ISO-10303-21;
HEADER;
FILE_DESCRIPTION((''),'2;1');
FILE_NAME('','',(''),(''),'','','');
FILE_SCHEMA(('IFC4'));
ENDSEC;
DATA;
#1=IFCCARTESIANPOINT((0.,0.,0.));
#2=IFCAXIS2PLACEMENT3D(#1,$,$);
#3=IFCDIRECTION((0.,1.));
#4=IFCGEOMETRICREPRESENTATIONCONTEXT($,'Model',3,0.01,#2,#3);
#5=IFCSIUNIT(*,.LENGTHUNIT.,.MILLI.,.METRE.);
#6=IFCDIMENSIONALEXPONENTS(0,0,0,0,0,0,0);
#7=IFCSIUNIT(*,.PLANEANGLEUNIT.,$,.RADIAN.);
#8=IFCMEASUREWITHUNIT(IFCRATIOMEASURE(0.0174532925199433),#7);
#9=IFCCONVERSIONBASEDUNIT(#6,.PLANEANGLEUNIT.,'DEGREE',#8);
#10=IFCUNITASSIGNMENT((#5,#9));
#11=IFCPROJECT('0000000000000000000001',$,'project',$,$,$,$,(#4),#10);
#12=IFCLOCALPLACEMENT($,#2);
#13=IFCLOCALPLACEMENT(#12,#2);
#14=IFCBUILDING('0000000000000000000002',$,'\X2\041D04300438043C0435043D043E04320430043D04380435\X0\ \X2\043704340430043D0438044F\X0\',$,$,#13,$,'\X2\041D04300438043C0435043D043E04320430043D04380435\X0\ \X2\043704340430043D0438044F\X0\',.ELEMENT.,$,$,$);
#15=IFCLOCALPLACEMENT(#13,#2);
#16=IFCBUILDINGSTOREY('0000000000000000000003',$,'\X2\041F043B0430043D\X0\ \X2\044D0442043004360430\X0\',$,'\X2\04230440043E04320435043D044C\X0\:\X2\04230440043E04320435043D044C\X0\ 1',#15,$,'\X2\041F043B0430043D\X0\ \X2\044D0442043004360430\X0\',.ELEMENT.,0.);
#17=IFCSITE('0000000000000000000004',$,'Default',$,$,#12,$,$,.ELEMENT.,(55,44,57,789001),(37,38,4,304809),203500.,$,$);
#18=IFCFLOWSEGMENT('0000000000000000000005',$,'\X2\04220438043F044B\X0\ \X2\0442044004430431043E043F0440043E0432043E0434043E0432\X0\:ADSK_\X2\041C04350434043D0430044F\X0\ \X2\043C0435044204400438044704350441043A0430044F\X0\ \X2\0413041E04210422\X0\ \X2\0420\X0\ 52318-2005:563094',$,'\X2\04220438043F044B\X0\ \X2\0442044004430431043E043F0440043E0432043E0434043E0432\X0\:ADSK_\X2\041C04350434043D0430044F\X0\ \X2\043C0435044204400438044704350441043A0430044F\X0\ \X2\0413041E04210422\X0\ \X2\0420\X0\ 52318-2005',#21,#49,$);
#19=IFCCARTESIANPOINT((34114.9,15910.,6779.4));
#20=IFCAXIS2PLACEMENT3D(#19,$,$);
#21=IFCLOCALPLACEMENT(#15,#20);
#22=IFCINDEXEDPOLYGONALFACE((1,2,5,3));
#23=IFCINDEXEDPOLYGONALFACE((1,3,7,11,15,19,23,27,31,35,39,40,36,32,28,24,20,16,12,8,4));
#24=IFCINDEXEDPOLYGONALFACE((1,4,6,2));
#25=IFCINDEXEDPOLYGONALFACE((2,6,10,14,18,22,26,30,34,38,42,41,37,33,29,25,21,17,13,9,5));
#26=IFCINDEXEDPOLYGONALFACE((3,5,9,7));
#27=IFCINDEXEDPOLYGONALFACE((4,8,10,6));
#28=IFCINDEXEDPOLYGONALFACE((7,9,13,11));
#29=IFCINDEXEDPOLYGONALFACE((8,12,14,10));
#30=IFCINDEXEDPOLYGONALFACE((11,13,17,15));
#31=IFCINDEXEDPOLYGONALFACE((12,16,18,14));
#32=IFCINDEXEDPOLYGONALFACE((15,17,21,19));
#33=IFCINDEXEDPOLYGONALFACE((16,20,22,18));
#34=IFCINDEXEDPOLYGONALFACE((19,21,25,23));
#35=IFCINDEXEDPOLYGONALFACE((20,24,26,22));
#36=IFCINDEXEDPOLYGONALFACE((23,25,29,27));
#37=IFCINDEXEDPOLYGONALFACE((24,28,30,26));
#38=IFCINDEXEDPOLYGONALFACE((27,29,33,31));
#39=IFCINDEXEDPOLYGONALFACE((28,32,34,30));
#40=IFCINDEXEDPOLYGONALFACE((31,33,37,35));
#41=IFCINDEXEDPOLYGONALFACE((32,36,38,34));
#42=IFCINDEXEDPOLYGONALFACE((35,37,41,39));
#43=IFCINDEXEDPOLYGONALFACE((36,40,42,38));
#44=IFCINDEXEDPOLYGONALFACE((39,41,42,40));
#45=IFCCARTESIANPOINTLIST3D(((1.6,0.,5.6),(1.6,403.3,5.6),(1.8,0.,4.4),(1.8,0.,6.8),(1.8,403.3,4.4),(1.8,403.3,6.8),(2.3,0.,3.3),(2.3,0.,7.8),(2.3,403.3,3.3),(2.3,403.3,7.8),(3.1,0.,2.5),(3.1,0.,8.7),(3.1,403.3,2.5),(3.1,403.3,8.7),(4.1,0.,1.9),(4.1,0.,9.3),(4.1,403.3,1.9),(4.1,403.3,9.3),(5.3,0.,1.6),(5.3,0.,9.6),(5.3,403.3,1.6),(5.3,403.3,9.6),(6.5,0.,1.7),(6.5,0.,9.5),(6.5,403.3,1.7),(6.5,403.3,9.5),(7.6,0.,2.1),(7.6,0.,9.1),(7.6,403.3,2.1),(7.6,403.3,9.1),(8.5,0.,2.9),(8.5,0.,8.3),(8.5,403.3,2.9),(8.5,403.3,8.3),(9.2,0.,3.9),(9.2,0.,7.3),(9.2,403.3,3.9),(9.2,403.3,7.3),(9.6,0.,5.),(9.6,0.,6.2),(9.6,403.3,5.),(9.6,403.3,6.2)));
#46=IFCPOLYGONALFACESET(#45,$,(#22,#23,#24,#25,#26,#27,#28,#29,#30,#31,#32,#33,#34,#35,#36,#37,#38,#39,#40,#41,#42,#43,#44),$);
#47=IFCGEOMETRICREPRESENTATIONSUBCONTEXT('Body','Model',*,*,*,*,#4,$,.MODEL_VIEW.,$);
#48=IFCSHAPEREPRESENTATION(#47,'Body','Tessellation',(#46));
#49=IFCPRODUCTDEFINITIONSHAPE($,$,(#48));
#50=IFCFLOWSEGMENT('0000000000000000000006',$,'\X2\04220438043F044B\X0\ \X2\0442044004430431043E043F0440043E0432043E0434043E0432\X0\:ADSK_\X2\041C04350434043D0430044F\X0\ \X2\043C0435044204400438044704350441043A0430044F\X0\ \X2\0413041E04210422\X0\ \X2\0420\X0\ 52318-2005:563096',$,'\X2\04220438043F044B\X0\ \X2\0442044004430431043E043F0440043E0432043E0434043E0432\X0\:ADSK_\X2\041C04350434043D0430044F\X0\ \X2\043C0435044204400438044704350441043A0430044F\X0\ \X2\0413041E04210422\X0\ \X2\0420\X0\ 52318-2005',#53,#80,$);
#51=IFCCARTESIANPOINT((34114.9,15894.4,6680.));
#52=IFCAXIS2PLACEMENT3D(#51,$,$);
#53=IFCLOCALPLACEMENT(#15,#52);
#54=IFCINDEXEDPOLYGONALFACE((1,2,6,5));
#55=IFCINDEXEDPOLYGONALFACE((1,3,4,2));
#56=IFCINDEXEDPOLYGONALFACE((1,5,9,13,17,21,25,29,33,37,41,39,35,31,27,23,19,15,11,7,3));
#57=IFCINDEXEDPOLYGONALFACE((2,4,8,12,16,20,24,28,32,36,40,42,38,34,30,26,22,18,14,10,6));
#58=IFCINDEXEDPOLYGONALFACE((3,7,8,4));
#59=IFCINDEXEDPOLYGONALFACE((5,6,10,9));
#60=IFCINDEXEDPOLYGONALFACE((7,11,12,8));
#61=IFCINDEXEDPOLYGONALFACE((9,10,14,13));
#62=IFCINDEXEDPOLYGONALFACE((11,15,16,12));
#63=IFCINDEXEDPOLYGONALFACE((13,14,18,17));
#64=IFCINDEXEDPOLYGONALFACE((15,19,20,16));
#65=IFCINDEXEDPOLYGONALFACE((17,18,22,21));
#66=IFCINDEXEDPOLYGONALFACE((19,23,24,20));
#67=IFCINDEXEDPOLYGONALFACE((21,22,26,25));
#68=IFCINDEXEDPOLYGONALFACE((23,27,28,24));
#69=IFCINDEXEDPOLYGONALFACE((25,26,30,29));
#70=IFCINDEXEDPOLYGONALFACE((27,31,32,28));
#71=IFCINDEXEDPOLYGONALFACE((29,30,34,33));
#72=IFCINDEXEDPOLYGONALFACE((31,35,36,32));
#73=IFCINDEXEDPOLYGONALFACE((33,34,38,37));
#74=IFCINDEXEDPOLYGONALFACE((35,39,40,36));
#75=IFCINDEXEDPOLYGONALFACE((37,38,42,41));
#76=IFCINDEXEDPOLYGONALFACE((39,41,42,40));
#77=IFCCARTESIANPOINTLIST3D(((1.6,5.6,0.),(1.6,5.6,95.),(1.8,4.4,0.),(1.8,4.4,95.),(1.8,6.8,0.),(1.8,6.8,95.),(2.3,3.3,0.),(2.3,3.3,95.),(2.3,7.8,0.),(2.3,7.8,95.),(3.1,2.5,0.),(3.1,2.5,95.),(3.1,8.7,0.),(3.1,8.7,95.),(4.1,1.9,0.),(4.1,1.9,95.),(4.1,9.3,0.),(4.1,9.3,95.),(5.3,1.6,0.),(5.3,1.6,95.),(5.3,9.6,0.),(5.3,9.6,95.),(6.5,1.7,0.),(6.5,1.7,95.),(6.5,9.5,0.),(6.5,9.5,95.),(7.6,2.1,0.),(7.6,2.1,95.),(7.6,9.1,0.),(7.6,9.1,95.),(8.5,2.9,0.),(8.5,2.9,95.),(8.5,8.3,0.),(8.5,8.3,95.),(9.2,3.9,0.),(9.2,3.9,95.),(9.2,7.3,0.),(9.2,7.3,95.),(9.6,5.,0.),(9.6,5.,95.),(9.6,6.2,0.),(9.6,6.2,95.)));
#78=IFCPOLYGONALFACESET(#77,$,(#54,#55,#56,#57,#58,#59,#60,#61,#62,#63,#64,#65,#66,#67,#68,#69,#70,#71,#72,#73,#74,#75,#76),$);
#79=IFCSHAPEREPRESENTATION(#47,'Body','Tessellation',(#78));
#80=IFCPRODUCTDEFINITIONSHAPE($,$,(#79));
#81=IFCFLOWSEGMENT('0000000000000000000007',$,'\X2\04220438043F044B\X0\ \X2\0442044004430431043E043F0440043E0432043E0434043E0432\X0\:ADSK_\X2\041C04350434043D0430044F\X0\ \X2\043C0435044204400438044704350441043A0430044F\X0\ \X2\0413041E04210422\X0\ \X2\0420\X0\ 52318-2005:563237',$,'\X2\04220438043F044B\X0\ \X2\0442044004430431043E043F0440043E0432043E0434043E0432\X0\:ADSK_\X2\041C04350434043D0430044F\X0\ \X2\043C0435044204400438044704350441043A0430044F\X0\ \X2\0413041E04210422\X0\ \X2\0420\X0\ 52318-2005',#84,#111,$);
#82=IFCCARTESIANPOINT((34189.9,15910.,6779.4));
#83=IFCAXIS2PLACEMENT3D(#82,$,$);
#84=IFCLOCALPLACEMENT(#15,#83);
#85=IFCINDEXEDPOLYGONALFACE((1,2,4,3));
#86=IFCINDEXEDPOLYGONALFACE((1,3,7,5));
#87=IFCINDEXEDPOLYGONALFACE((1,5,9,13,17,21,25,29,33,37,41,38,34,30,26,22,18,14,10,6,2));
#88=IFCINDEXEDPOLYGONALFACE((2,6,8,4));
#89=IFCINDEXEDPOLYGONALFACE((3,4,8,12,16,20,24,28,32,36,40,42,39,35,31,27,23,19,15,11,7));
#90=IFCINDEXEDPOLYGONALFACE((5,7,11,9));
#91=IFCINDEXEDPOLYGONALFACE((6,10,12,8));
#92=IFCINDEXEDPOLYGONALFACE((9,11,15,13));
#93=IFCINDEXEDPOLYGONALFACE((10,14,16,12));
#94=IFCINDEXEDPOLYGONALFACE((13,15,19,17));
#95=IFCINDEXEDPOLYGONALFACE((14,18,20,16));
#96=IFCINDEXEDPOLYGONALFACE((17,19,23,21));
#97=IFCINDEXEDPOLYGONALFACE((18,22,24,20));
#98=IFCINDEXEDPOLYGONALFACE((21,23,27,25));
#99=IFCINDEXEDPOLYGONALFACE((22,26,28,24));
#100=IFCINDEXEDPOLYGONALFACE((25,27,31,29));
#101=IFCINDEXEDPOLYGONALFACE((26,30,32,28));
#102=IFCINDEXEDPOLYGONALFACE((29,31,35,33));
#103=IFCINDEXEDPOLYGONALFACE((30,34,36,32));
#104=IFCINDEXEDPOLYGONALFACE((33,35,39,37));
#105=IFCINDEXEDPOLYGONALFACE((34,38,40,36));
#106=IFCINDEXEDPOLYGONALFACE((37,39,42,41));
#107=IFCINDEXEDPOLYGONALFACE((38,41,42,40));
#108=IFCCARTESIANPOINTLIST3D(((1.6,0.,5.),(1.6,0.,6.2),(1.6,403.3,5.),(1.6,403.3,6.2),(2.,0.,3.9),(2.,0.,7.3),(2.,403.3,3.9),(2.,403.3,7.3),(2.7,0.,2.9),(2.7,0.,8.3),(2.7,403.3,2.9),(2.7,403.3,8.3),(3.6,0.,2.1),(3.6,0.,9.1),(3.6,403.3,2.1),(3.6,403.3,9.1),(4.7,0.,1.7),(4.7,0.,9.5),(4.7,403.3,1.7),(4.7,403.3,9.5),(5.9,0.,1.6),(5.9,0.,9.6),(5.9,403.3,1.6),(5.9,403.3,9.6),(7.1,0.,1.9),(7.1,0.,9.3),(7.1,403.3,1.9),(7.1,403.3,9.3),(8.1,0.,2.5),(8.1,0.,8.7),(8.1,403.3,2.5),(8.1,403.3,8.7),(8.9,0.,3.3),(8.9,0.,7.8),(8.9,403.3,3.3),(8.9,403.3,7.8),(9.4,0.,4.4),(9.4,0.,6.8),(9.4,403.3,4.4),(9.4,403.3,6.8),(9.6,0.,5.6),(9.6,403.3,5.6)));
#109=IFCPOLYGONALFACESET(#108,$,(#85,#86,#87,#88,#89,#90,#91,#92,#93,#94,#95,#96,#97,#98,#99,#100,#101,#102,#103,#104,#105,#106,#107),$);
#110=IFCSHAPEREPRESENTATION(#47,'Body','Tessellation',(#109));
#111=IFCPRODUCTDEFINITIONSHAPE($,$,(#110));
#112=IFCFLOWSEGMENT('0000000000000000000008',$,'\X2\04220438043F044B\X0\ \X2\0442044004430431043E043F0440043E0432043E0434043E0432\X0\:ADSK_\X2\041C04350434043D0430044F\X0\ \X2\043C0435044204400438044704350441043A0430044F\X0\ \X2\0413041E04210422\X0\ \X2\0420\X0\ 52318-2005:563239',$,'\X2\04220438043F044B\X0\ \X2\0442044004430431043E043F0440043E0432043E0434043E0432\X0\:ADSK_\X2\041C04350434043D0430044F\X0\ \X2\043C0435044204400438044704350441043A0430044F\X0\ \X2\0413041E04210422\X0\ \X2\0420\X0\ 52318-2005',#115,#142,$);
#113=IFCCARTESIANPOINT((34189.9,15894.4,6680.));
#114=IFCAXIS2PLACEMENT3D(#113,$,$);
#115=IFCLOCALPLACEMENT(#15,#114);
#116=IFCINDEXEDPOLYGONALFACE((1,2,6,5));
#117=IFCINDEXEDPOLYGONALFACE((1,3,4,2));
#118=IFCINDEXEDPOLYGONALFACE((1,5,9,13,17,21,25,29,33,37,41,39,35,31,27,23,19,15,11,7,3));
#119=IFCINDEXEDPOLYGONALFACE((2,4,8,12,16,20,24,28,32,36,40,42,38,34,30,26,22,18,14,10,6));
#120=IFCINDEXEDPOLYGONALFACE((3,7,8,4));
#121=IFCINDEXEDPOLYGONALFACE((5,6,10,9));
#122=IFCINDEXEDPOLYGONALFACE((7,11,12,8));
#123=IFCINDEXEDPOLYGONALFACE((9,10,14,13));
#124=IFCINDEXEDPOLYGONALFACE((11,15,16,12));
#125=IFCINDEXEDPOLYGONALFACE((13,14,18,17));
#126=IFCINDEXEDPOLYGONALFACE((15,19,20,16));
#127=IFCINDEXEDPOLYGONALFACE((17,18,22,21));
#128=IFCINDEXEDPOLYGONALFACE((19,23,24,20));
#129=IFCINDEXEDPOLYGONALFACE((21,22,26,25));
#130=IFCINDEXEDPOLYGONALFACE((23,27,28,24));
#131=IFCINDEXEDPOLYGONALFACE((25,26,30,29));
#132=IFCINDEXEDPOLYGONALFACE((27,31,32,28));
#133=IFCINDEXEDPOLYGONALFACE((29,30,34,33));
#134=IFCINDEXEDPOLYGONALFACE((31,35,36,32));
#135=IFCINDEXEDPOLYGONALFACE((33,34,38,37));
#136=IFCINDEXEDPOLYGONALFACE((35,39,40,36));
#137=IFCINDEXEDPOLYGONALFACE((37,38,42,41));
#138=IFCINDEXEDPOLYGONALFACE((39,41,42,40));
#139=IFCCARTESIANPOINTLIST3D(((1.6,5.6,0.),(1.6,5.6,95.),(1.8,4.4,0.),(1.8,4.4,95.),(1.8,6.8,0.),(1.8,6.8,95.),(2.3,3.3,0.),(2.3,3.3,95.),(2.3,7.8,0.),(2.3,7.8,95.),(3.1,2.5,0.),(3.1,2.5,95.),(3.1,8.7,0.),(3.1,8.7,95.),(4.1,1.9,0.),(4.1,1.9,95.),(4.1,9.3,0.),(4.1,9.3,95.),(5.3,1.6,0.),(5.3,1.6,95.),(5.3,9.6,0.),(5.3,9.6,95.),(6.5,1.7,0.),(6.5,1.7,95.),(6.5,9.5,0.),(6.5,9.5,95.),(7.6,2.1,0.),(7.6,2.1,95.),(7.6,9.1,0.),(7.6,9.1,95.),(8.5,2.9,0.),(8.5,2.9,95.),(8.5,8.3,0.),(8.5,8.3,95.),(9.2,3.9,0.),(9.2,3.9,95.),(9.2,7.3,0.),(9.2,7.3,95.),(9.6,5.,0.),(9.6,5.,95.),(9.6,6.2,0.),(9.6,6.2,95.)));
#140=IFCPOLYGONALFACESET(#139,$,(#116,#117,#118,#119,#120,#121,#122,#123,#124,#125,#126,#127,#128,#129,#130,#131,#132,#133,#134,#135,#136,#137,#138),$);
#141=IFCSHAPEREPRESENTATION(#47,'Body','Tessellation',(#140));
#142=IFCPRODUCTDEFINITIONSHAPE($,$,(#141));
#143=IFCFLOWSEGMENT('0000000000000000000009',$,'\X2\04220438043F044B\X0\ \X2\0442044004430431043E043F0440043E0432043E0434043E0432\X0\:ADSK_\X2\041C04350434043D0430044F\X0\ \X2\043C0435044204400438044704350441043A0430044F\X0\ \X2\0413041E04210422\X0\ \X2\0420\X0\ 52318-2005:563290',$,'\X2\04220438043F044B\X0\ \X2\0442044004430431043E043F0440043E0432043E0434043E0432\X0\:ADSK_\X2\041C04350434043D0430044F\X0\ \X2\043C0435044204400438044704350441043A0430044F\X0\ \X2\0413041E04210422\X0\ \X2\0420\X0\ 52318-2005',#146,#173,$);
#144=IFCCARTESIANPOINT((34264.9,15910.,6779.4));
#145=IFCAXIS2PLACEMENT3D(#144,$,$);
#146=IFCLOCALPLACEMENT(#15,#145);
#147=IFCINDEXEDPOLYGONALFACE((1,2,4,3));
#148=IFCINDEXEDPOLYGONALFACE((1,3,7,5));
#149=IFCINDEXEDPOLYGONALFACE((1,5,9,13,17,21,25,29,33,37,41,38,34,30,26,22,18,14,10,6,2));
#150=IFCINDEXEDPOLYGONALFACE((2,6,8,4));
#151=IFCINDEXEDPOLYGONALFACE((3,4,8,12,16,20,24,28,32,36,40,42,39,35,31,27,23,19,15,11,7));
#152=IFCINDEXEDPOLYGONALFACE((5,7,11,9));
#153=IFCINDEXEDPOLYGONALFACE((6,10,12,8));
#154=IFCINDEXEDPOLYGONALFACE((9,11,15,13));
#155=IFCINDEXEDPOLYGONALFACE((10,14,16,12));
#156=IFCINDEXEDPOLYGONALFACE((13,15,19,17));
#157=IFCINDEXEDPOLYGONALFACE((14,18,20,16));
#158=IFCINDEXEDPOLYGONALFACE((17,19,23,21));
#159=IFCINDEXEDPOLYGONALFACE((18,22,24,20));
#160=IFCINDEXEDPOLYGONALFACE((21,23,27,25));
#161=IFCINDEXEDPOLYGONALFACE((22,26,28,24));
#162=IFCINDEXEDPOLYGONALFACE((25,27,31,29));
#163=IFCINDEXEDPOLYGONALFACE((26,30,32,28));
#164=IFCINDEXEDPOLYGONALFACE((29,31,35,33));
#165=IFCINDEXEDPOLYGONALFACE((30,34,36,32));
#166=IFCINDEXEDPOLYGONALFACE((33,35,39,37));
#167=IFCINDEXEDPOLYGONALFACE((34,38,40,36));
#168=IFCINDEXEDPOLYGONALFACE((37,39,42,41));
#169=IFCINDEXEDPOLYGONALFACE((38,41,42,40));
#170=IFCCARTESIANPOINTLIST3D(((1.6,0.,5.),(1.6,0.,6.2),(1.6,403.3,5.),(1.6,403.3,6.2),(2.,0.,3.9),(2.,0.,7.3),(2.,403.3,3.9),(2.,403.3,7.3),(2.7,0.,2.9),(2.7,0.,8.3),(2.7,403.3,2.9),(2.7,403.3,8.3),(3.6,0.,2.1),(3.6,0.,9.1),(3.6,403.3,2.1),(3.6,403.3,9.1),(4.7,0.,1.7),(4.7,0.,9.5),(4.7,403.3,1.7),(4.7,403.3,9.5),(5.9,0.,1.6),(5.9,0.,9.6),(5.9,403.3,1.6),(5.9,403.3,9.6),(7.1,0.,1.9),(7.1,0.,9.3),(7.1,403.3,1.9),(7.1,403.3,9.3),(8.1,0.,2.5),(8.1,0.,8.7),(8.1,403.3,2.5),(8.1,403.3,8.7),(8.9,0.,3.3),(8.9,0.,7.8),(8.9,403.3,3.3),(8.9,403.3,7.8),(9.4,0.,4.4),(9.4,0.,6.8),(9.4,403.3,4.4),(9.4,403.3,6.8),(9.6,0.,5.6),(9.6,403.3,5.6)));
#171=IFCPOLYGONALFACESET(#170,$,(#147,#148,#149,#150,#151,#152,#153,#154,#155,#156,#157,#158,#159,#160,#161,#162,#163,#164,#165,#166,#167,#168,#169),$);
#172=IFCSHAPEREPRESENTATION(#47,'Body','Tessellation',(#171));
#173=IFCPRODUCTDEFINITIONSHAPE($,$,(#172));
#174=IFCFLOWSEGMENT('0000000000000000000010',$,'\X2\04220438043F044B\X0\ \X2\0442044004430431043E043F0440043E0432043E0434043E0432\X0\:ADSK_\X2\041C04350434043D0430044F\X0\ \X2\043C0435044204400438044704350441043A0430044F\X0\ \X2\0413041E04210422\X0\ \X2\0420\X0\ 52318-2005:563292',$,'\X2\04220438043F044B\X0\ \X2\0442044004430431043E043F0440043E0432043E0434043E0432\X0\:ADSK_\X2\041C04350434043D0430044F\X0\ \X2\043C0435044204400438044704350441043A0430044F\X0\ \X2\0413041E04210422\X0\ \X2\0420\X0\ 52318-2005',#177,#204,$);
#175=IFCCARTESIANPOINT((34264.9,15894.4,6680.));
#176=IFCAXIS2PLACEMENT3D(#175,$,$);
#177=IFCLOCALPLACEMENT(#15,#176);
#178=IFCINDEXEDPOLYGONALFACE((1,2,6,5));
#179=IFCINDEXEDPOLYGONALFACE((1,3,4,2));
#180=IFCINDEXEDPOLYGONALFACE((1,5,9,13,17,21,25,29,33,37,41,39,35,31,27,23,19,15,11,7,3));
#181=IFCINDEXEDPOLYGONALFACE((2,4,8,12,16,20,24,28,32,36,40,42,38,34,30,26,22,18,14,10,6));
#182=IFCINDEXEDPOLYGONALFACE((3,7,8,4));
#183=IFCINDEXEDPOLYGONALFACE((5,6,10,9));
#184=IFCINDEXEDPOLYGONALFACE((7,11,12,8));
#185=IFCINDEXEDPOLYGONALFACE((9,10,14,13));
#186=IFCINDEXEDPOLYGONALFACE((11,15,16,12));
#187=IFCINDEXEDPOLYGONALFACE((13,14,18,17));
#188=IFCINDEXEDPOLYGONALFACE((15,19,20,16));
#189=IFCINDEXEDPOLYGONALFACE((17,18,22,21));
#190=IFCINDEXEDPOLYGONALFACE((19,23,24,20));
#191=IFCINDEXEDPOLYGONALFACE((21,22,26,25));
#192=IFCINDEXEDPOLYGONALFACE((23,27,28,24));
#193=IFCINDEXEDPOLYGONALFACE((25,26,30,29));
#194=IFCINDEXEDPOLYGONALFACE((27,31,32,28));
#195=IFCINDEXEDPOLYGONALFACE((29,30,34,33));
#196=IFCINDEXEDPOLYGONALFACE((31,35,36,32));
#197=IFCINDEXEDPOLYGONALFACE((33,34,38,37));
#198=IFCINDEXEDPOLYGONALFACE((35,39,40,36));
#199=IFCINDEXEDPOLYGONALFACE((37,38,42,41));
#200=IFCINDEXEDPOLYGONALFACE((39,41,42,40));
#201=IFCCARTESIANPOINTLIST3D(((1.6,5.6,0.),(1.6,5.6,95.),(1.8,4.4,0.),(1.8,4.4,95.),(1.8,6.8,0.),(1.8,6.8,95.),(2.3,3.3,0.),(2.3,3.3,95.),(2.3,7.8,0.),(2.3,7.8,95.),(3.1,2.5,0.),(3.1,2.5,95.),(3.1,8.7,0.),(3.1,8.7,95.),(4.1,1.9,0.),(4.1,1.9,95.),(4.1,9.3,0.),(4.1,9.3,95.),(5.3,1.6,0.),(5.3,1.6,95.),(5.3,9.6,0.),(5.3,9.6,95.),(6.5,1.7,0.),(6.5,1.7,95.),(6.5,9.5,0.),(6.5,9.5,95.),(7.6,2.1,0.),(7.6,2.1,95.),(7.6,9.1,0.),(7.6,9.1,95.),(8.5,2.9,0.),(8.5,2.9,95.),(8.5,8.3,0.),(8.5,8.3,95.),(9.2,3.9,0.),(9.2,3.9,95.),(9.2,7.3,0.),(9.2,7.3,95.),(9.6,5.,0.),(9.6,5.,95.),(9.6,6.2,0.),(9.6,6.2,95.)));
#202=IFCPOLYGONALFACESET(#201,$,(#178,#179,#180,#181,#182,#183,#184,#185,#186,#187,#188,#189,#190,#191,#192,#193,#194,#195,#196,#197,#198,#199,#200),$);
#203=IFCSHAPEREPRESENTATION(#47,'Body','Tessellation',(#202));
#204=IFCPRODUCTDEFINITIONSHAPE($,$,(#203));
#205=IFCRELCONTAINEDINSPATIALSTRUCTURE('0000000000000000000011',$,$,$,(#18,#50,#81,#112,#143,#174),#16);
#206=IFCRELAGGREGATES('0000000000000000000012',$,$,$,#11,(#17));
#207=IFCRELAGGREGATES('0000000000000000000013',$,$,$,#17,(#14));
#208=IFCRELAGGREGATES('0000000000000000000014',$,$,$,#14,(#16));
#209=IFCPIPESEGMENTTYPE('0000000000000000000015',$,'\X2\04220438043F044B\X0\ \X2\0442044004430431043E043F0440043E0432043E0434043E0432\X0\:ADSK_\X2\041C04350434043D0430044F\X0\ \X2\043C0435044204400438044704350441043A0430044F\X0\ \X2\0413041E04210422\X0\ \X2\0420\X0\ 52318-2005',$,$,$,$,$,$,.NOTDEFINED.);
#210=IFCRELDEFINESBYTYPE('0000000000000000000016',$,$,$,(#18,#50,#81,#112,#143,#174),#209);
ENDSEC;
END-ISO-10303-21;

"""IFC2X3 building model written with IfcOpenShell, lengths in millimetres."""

from ifc_helpers import new_model, entity, si_unit, converted_unit, direction, frame, frame_2d, origin, origin_2d_with_axis, place, context, subcontext, project, spatial, circle, extrude, type_object, element, save


model = new_model("IFC2X3")

# Units and contexts
model_context = context("Model", 3, precision=0.01, world=origin(), true_north=direction((0.0, 1.0)))
body_context = subcontext(model_context, "Body", "Model", "MODEL_VIEW")
ifc_project = project(units=[si_unit("LENGTHUNIT", "METRE", prefix="MILLI"), converted_unit("PLANEANGLEUNIT", "DEGREE", entity("IfcRatioMeasure", 0.0174532925199433), si_unit("PLANEANGLEUNIT", "RADIAN"), dimensions=[0, 0, 0, 0, 0, 0, 0])], contexts=[model_context])

# Site, building, storey
site_placement = place(None, frame((0.0, 0.0, 0.0)))
site = spatial("IfcSite", under=ifc_project, at=site_placement, Name="Default", CompositionType="ELEMENT", RefLatitude=(55, 44, 57, 789001), RefLongitude=(37, 38, 4, 304809), RefElevation=203500.0)
building_placement = place(site_placement, origin())
building = spatial("IfcBuilding", under=site, at=building_placement, Name="Наименование здания", LongName="Наименование здания", CompositionType="ELEMENT")
storey_placement = place(building_placement, origin())
storey = spatial("IfcBuildingStorey", under=building, at=storey_placement, Name="План этажа", ObjectType="Уровень:Уровень 1", LongName="План этажа", CompositionType="ELEMENT", Elevation=0.0)

# Flow segments
pipe_segment_type = type_object("IfcPipeSegmentType", Name="Типы трубопроводов:ADSK_Медная метрическая ГОСТ Р 52318-2005", PredefinedType="NOTDEFINED")
flow_segment_1_placement = place(storey_placement, frame((34114.9, 15910.0, 6779.4)))
element("IfcFlowSegment", 1, at=flow_segment_1_placement, inside=storey, type_object=pipe_segment_type, Name="Типы трубопроводов:ADSK_Медная метрическая ГОСТ Р 52318-2005:563094", ObjectType="Типы трубопроводов:ADSK_Медная метрическая ГОСТ Р 52318-2005", context=body_context, shape_type="SweptSolid", body=[
    extrude(circle(Radius=4.0, at=frame_2d((0.0, 0.0), x_axis=(1.0, 0.0))), frame((5.6, 0.0, 5.6), z_axis=(0.0, 1.0, 0.0), x_axis=(-1.0, 0.0, 0.0)), (0.0, 0.0, 1.0), 403.3),
])
flow_segment_2_placement = place(storey_placement, frame((34114.9, 15894.4, 6680.0)))
element("IfcFlowSegment", 2, at=flow_segment_2_placement, inside=storey, type_object=pipe_segment_type, Name="Типы трубопроводов:ADSK_Медная метрическая ГОСТ Р 52318-2005:563096", ObjectType="Типы трубопроводов:ADSK_Медная метрическая ГОСТ Р 52318-2005", context=body_context, shape_type="SweptSolid", body=[
    extrude(circle(Radius=4.0, at=origin_2d_with_axis()), frame((5.6, 5.6, 0.0), z_axis=(0.0, 0.0, 1.0), x_axis=(-1.0, 0.0, 0.0)), (0.0, 0.0, 1.0), 95.0),
])
flow_segment_3_placement = place(storey_placement, frame((34189.9, 15910.0, 6779.4)))
element("IfcFlowSegment", 3, at=flow_segment_3_placement, inside=storey, type_object=pipe_segment_type, Name="Типы трубопроводов:ADSK_Медная метрическая ГОСТ Р 52318-2005:563237", ObjectType="Типы трубопроводов:ADSK_Медная метрическая ГОСТ Р 52318-2005", context=body_context, shape_type="SweptSolid", body=[
    extrude(circle(Radius=4.0, at=origin_2d_with_axis()), frame((5.6, 0.0, 5.6), z_axis=(0.0, 1.0, 0.0), x_axis=(1.0, 0.0, 0.0)), (0.0, 0.0, 1.0), 403.3),
])
flow_segment_4_placement = place(storey_placement, frame((34189.9, 15894.4, 6680.0)))
element("IfcFlowSegment", 4, at=flow_segment_4_placement, inside=storey, type_object=pipe_segment_type, Name="Типы трубопроводов:ADSK_Медная метрическая ГОСТ Р 52318-2005:563239", ObjectType="Типы трубопроводов:ADSK_Медная метрическая ГОСТ Р 52318-2005", context=body_context, shape_type="SweptSolid", body=[
    extrude(circle(Radius=4.0, at=origin_2d_with_axis()), frame((5.6, 5.6, 0.0), z_axis=(0.0, 0.0, 1.0), x_axis=(-1.0, 0.0, 0.0)), (0.0, 0.0, 1.0), 95.0),
])
flow_segment_5_placement = place(storey_placement, frame((34264.9, 15910.0, 6779.4)))
element("IfcFlowSegment", 5, at=flow_segment_5_placement, inside=storey, type_object=pipe_segment_type, Name="Типы трубопроводов:ADSK_Медная метрическая ГОСТ Р 52318-2005:563290", ObjectType="Типы трубопроводов:ADSK_Медная метрическая ГОСТ Р 52318-2005", context=body_context, shape_type="SweptSolid", body=[
    extrude(circle(Radius=4.0, at=origin_2d_with_axis()), frame((5.6, 0.0, 5.6), z_axis=(0.0, 1.0, 0.0), x_axis=(1.0, 0.0, 0.0)), (0.0, 0.0, 1.0), 403.3),
])
flow_segment_6_placement = place(storey_placement, frame((34264.9, 15894.4, 6680.0)))
element("IfcFlowSegment", 6, at=flow_segment_6_placement, inside=storey, type_object=pipe_segment_type, Name="Типы трубопроводов:ADSK_Медная метрическая ГОСТ Р 52318-2005:563292", ObjectType="Типы трубопроводов:ADSK_Медная метрическая ГОСТ Р 52318-2005", context=body_context, shape_type="SweptSolid", body=[
    extrude(circle(Radius=4.0, at=origin_2d_with_axis()), frame((5.6, 5.6, 0.0), z_axis=(0.0, 0.0, 1.0), x_axis=(-1.0, 0.0, 0.0)), (0.0, 0.0, 1.0), 95.0),
])

save(model, "model.ifc")
